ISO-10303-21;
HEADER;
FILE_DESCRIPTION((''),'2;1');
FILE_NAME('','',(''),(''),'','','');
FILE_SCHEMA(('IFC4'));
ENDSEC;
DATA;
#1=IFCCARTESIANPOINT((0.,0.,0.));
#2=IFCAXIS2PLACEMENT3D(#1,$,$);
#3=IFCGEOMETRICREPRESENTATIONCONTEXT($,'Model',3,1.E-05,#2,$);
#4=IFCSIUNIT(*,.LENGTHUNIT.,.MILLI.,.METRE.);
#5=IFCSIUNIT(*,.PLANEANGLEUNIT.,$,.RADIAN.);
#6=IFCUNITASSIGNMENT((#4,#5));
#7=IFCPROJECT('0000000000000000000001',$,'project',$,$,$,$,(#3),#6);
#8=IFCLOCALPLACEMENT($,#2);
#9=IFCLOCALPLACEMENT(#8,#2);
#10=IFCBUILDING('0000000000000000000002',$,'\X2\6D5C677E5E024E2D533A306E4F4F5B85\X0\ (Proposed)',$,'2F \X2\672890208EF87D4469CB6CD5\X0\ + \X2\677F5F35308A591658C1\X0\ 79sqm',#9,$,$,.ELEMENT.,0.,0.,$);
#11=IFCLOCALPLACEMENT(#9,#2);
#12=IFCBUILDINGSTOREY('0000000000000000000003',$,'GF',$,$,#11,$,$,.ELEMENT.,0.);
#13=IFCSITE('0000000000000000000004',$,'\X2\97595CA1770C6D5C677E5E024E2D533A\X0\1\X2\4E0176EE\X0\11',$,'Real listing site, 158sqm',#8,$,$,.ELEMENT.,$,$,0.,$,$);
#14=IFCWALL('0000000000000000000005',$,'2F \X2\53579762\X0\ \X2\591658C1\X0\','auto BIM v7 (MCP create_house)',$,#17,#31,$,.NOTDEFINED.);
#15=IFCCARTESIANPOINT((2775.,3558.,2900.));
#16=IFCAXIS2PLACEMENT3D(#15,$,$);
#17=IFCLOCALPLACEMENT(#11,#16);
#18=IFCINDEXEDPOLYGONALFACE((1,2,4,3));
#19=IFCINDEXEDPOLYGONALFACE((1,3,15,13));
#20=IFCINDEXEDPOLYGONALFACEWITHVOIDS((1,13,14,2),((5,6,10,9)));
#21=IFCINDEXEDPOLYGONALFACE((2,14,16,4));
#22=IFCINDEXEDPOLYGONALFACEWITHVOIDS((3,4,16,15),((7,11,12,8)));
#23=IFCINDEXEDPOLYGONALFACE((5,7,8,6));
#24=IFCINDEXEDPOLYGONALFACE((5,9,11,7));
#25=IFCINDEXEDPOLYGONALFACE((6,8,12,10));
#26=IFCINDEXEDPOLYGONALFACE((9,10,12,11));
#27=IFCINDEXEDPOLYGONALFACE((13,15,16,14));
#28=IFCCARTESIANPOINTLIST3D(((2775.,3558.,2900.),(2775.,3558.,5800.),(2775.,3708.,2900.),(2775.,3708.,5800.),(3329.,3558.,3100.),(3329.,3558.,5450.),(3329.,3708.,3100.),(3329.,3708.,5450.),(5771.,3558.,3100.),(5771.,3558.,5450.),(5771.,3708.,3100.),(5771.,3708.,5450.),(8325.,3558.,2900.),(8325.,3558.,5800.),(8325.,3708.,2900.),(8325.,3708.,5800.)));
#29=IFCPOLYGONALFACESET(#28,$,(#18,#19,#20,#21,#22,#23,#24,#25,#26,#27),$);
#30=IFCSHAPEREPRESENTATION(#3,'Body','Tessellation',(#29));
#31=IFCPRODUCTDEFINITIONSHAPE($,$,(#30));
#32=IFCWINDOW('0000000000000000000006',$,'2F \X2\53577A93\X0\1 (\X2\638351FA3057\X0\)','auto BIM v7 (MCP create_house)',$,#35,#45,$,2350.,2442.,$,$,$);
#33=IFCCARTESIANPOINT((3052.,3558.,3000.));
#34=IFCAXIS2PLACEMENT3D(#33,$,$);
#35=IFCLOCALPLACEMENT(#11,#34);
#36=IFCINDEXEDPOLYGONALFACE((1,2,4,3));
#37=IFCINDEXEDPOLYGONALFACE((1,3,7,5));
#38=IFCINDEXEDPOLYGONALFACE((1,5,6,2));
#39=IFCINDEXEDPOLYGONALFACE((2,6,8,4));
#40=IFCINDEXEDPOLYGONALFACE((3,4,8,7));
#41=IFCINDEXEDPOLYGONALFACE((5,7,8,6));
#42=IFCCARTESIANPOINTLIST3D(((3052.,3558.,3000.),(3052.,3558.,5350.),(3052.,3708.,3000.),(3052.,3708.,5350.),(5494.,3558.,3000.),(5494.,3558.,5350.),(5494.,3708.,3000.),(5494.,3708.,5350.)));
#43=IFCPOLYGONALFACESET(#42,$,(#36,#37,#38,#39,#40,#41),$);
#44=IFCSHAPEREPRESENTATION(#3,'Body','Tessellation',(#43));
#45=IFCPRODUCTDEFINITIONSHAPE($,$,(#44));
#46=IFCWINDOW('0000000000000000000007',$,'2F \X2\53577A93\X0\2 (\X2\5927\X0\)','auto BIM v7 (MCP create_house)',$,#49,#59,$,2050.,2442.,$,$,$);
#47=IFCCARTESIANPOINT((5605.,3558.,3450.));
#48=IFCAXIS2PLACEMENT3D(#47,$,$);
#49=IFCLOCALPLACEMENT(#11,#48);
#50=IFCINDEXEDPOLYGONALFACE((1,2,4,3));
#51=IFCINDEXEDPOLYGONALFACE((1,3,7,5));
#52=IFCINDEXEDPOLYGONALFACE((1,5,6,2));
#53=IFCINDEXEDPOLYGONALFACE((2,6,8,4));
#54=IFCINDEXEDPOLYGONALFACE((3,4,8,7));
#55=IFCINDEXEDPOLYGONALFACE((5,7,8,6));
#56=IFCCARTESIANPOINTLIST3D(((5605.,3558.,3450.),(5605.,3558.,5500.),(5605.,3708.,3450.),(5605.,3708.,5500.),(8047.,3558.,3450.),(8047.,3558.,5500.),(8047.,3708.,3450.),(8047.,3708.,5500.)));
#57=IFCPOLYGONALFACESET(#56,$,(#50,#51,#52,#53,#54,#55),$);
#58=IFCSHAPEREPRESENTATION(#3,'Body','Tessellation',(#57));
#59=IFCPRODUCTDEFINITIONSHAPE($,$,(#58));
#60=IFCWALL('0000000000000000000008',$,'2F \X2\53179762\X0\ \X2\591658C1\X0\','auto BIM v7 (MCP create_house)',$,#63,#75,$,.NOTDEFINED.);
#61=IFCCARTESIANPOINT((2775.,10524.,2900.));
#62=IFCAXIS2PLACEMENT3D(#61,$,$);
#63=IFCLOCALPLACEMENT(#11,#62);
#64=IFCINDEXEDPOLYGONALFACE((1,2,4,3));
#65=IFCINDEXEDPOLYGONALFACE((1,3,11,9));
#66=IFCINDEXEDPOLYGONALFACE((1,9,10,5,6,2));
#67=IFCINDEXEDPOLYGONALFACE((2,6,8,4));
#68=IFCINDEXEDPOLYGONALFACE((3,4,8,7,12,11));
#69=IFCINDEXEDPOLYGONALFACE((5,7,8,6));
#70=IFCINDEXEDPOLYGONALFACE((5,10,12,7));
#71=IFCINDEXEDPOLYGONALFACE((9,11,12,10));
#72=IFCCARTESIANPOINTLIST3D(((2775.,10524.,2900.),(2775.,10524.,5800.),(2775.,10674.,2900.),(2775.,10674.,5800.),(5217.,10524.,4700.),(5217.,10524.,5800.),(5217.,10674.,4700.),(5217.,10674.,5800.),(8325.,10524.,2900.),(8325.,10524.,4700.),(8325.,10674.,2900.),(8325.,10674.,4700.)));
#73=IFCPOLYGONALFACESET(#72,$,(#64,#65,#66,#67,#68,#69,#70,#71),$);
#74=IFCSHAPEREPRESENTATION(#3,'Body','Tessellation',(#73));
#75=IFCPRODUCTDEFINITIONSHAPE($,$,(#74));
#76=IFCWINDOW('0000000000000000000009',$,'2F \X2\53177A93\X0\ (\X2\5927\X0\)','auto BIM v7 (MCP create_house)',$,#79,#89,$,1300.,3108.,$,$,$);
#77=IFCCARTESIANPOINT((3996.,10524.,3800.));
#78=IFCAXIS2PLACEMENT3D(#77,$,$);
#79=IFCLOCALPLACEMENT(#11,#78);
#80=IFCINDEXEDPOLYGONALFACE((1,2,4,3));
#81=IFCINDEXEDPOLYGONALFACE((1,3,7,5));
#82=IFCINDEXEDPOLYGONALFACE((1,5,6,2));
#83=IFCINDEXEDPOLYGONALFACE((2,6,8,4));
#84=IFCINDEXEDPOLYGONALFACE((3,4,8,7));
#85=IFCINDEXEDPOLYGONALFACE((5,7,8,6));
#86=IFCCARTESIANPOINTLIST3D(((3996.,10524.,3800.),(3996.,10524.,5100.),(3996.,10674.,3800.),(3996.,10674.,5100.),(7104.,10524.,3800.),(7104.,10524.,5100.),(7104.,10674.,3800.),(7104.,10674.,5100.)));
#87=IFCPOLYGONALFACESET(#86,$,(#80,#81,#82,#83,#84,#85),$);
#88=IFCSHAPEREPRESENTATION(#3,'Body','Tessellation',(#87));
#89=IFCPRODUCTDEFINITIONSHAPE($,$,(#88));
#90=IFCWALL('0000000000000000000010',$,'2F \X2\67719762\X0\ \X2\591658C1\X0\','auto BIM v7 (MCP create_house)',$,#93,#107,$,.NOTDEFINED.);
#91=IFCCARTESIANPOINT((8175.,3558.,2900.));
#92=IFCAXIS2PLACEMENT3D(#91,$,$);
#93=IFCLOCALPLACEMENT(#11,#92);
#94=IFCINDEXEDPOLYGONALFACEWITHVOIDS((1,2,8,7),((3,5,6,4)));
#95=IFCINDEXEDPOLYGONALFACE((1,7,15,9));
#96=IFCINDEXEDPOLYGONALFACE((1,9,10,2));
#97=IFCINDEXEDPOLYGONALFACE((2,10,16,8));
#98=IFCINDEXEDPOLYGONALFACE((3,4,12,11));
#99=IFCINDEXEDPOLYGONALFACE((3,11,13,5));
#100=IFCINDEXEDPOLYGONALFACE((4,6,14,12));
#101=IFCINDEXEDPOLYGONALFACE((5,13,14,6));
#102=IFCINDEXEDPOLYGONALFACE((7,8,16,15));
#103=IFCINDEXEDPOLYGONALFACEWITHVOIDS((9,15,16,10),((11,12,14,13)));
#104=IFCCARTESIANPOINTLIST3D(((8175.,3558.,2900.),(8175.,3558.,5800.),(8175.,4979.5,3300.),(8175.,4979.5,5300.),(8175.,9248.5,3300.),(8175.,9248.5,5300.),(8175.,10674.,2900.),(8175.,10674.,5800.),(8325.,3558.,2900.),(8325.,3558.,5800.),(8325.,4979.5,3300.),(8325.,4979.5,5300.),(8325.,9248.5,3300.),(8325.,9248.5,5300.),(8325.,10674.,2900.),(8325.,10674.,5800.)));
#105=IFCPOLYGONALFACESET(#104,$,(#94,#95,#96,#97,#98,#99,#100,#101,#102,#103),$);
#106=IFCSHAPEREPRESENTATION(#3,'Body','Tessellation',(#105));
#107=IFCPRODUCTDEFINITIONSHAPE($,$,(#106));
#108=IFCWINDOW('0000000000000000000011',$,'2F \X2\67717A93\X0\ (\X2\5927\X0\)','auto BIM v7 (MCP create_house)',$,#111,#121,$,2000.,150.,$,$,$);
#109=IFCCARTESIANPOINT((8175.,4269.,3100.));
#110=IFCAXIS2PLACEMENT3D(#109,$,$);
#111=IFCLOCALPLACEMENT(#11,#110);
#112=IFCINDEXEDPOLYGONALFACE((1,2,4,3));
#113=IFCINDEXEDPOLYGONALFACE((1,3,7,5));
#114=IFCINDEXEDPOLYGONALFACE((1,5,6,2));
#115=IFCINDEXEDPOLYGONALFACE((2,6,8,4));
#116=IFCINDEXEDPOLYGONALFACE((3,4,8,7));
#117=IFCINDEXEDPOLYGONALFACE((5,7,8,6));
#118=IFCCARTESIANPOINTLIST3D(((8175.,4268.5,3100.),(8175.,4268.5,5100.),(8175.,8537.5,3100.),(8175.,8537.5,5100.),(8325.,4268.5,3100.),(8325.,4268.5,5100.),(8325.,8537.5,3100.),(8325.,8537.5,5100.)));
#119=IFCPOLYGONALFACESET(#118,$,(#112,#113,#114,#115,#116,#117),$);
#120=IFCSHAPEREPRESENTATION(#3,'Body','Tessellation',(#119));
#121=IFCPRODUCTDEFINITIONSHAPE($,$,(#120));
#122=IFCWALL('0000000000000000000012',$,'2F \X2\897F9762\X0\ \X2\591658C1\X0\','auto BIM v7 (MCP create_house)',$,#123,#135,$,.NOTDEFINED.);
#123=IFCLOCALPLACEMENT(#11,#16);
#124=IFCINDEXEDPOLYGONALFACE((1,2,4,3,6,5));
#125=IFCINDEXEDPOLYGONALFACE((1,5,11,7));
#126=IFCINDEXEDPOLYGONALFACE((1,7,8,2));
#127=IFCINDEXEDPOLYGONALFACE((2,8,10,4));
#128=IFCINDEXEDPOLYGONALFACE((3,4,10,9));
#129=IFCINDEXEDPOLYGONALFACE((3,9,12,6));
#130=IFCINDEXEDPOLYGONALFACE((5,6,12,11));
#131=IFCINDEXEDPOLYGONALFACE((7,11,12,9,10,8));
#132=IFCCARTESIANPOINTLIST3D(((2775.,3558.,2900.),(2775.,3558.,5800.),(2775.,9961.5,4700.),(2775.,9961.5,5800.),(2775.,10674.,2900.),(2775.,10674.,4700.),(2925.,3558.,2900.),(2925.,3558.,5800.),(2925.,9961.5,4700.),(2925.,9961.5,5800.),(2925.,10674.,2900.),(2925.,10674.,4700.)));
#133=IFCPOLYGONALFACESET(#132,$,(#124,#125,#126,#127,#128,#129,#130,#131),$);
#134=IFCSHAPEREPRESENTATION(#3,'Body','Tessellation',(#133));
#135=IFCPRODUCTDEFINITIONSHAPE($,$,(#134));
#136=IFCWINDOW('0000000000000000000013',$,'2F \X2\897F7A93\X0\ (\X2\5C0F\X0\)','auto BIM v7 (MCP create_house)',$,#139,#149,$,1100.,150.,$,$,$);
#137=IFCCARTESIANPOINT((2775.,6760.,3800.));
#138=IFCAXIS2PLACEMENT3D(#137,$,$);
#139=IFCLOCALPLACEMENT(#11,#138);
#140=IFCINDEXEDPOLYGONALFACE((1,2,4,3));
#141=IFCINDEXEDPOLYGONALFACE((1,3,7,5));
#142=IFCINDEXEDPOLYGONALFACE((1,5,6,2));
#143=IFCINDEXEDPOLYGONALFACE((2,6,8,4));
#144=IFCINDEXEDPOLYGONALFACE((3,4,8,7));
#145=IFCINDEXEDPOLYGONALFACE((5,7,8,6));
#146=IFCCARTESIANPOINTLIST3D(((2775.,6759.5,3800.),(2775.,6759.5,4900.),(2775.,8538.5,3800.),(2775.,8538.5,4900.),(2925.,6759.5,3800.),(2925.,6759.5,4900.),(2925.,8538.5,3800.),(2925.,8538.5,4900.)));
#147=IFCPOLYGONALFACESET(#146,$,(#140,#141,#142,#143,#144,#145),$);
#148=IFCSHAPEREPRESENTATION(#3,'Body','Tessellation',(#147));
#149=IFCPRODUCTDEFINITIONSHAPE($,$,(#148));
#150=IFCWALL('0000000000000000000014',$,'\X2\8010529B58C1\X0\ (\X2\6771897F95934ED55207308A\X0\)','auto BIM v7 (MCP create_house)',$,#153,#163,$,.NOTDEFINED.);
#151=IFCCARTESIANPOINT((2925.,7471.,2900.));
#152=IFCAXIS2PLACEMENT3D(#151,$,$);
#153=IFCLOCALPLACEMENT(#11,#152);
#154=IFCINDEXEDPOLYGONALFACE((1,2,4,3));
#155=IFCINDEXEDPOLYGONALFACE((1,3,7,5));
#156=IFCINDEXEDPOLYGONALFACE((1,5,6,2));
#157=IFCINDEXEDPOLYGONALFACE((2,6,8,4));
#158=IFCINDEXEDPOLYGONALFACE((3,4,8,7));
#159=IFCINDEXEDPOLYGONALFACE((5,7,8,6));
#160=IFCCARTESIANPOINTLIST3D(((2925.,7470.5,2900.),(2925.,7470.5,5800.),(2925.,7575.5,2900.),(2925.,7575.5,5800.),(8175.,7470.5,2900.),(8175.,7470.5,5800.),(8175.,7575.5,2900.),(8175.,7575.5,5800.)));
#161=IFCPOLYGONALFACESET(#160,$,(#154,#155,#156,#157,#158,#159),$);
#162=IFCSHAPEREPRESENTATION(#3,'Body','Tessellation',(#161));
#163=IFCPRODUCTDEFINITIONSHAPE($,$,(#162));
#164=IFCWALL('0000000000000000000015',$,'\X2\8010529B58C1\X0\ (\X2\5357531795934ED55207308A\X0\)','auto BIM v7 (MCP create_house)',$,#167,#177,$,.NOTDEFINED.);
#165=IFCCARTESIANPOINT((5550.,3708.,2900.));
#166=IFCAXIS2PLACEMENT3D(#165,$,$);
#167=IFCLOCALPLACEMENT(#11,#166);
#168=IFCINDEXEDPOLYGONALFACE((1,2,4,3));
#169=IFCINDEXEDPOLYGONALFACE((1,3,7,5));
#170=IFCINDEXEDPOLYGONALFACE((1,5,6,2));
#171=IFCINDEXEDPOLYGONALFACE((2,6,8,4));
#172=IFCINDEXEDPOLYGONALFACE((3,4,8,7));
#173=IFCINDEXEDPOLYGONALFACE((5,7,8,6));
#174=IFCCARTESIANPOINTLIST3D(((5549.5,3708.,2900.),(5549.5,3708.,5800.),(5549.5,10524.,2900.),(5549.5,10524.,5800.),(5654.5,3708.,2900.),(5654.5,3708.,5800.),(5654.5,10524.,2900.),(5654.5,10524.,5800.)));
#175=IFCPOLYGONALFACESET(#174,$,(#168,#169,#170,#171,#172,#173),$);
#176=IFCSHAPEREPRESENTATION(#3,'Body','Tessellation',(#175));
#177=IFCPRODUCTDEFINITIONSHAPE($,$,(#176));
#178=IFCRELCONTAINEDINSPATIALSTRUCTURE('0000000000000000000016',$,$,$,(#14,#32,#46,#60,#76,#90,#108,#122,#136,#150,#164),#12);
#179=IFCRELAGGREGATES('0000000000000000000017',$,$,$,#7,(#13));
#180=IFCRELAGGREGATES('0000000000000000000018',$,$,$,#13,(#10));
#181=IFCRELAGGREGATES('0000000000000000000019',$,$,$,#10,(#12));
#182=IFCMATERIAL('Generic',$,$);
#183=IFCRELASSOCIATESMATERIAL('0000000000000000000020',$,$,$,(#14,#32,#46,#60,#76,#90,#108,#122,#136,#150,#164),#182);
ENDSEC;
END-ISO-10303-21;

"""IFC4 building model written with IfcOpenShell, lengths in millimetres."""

from ifc_helpers import new_model, si_unit, frame, frame_2d, origin, place, context, project, spatial, rectangle, extrude, material, element, fill, save


model = new_model("IFC4")

# Units and contexts
model_context = context("Model", 3, precision=1e-05, world=origin())
ifc_project = project(units=[si_unit("LENGTHUNIT", "METRE", prefix="MILLI"), si_unit("PLANEANGLEUNIT", "RADIAN")], contexts=[model_context])

# Site, building, storey
site_placement = place(None, origin())
site = spatial("IfcSite", under=ifc_project, at=site_placement, Name="静岡県浜松市中区1丁目11", ObjectType="Real listing site, 158sqm", CompositionType="ELEMENT", RefElevation=0.0)
building_placement = place(site_placement, origin())
building = spatial("IfcBuilding", under=site, at=building_placement, Name="浜松市中区の住宅 (Proposed)", ObjectType="2F 木造軸組構法 + 板張り外壁 79sqm", CompositionType="ELEMENT", ElevationOfRefHeight=0.0, ElevationOfTerrain=0.0)
storey_placement = place(building_placement, origin())
storey = spatial("IfcBuildingStorey", under=building, at=storey_placement, Name="GF", CompositionType="ELEMENT", Elevation=0.0)

# Shared definitions
ifc_material = material(Name="Generic")

# Wall, openings, windows
wall_1_placement = place(storey_placement, frame((2775.0, 3558.0, 2900.0)))
wall_1 = element("IfcWall", 1, at=wall_1_placement, inside=storey, material=ifc_material, Name="2F 南面 外壁", Description="auto BIM v7 (MCP create_house)", PredefinedType="NOTDEFINED", context=model_context, shape_type="SweptSolid", body=[
    extrude(rectangle(XDim=5550.0, YDim=150.0, at=frame_2d((2775.0, 75.0))), frame((2775.0, 3558.0, 2900.0)), (0.0, 0.0, 1.0), 2900.0),
])
opening_1_placement = place(storey_placement, frame((3052.0, 3558.0, 3000.0)))
opening_1 = element("IfcOpeningElement", 2, at=opening_1_placement, cuts=wall_1, PredefinedType="NOTDEFINED", context=model_context, shape_type="SweptSolid", body=[
    extrude(rectangle(XDim=2442.0, YDim=150.0, at=frame_2d((1221.0, 75.0))), frame((3052.0, 3558.0, 3000.0)), (0.0, 0.0, 1.0), 2350.0),
])
opening_2_placement = place(storey_placement, frame((5605.0, 3558.0, 3450.0)))
opening_2 = element("IfcOpeningElement", 3, at=opening_2_placement, cuts=wall_1, PredefinedType="NOTDEFINED", context=model_context, shape_type="SweptSolid", body=[
    extrude(rectangle(XDim=2442.0, YDim=150.0, at=frame_2d((1221.0, 75.0))), frame((5605.0, 3558.0, 3450.0)), (0.0, 0.0, 1.0), 2050.0),
])
window_1_placement = place(storey_placement, frame((3052.0, 3558.0, 3000.0)))
window_1 = element("IfcWindow", 4, at=window_1_placement, inside=storey, material=ifc_material, Name="2F 南窓1 (掃出し)", Description="auto BIM v7 (MCP create_house)", OverallHeight=2350.0, OverallWidth=2442.0, context=model_context, shape_type="SweptSolid", body=[
    extrude(rectangle(XDim=2442.0, YDim=150.0, at=frame_2d((1221.0, 75.0))), frame((3052.0, 3558.0, 3000.0)), (0.0, 0.0, 1.0), 2350.0),
])
fill(opening_1, window_1)
window_2_placement = place(storey_placement, frame((5605.0, 3558.0, 3450.0)))
window_2 = element("IfcWindow", 5, at=window_2_placement, inside=storey, material=ifc_material, Name="2F 南窓2 (大)", Description="auto BIM v7 (MCP create_house)", OverallHeight=2050.0, OverallWidth=2442.0, context=model_context, shape_type="SweptSolid", body=[
    extrude(rectangle(XDim=2442.0, YDim=150.0, at=frame_2d((1221.0, 75.0))), frame((5605.0, 3558.0, 3450.0)), (0.0, 0.0, 1.0), 2050.0),
])
fill(opening_2, window_2)

# Walls, openings, windows
wall_2_placement = place(storey_placement, frame((2775.0, 10524.0, 2900.0)))
wall_2 = element("IfcWall", 6, at=wall_2_placement, inside=storey, material=ifc_material, Name="2F 北面 外壁", Description="auto BIM v7 (MCP create_house)", PredefinedType="NOTDEFINED", context=model_context, shape_type="SweptSolid", body=[
    extrude(rectangle(XDim=5550.0, YDim=150.0, at=frame_2d((2775.0, 75.0))), frame((2775.0, 10524.0, 2900.0)), (0.0, 0.0, 1.0), 2900.0),
])
opening_3_placement = place(storey_placement, frame((3996.0, 10524.0, 3800.0)))
opening_3 = element("IfcOpeningElement", 7, at=opening_3_placement, cuts=wall_2, PredefinedType="NOTDEFINED", context=model_context, shape_type="SweptSolid", body=[
    extrude(rectangle(XDim=3108.0, YDim=150.0, at=frame_2d((1554.0, 75.0))), frame((3996.0, 10524.0, 3800.0)), (0.0, 0.0, 1.0), 1300.0),
])
window_3_placement = place(storey_placement, frame((3996.0, 10524.0, 3800.0)))
window_3 = element("IfcWindow", 8, at=window_3_placement, inside=storey, material=ifc_material, Name="2F 北窓 (大)", Description="auto BIM v7 (MCP create_house)", OverallHeight=1300.0, OverallWidth=3108.0, context=model_context, shape_type="SweptSolid", body=[
    extrude(rectangle(XDim=3108.0, YDim=150.0, at=frame_2d((1554.0, 75.0))), frame((3996.0, 10524.0, 3800.0)), (0.0, 0.0, 1.0), 1300.0),
])
fill(opening_3, window_3)
wall_3_placement = place(storey_placement, frame((8175.0, 3558.0, 2900.0)))
wall_3 = element("IfcWall", 9, at=wall_3_placement, inside=storey, material=ifc_material, Name="2F 東面 外壁", Description="auto BIM v7 (MCP create_house)", PredefinedType="NOTDEFINED", context=model_context, shape_type="SweptSolid", body=[
    extrude(rectangle(XDim=150.0, YDim=7116.0, at=frame_2d((75.0, 3558.0))), frame((8175.0, 3558.0, 2900.0)), (0.0, 0.0, 1.0), 2900.0),
])
opening_4_placement = place(storey_placement, frame((8175.0, 4269.0, 3100.0)))
opening_4 = element("IfcOpeningElement", 10, at=opening_4_placement, cuts=wall_3, PredefinedType="NOTDEFINED", context=model_context, shape_type="SweptSolid", body=[
    extrude(rectangle(XDim=150.0, YDim=4269.0, at=frame_2d((75.0, 2134.0))), frame((8175.0, 4269.0, 3100.0)), (0.0, 0.0, 1.0), 2000.0),
])
window_4_placement = place(storey_placement, frame((8175.0, 4269.0, 3100.0)))
window_4 = element("IfcWindow", 11, at=window_4_placement, inside=storey, material=ifc_material, Name="2F 東窓 (大)", Description="auto BIM v7 (MCP create_house)", OverallHeight=2000.0, OverallWidth=150.0, context=model_context, shape_type="SweptSolid", body=[
    extrude(rectangle(XDim=150.0, YDim=4269.0, at=frame_2d((75.0, 2134.0))), frame((8175.0, 4269.0, 3100.0)), (0.0, 0.0, 1.0), 2000.0),
])
fill(opening_4, window_4)
wall_4_placement = place(storey_placement, frame((2775.0, 3558.0, 2900.0)))
wall_4 = element("IfcWall", 12, at=wall_4_placement, inside=storey, material=ifc_material, Name="2F 西面 外壁", Description="auto BIM v7 (MCP create_house)", PredefinedType="NOTDEFINED", context=model_context, shape_type="SweptSolid", body=[
    extrude(rectangle(XDim=150.0, YDim=7116.0, at=frame_2d((75.0, 3558.0))), frame((2775.0, 3558.0, 2900.0)), (0.0, 0.0, 1.0), 2900.0),
])
opening_5_placement = place(storey_placement, frame((2775.0, 6760.0, 3800.0)))
opening_5 = element("IfcOpeningElement", 13, at=opening_5_placement, cuts=wall_4, PredefinedType="NOTDEFINED", context=model_context, shape_type="SweptSolid", body=[
    extrude(rectangle(XDim=150.0, YDim=1779.0, at=frame_2d((75.0, 889.0))), frame((2775.0, 6760.0, 3800.0)), (0.0, 0.0, 1.0), 1100.0),
])
window_5_placement = place(storey_placement, frame((2775.0, 6760.0, 3800.0)))
window_5 = element("IfcWindow", 14, at=window_5_placement, inside=storey, material=ifc_material, Name="2F 西窓 (小)", Description="auto BIM v7 (MCP create_house)", OverallHeight=1100.0, OverallWidth=150.0, context=model_context, shape_type="SweptSolid", body=[
    extrude(rectangle(XDim=150.0, YDim=1779.0, at=frame_2d((75.0, 889.0))), frame((2775.0, 6760.0, 3800.0)), (0.0, 0.0, 1.0), 1100.0),
])
fill(opening_5, window_5)

# Walls
wall_5_placement = place(storey_placement, frame((2925.0, 7471.0, 2900.0)))
element("IfcWall", 15, at=wall_5_placement, inside=storey, material=ifc_material, Name="耐力壁 (東西間仕切り)", Description="auto BIM v7 (MCP create_house)", PredefinedType="NOTDEFINED", context=model_context, shape_type="SweptSolid", body=[
    extrude(rectangle(XDim=5250.0, YDim=105.0, at=frame_2d((2625.0, 52.0))), frame((2925.0, 7471.0, 2900.0)), (0.0, 0.0, 1.0), 2900.0),
])
wall_6_placement = place(storey_placement, frame((5550.0, 3708.0, 2900.0)))
element("IfcWall", 16, at=wall_6_placement, inside=storey, material=ifc_material, Name="耐力壁 (南北間仕切り)", Description="auto BIM v7 (MCP create_house)", PredefinedType="NOTDEFINED", context=model_context, shape_type="SweptSolid", body=[
    extrude(rectangle(XDim=105.0, YDim=6816.0, at=frame_2d((52.0, 3408.0))), frame((5550.0, 3708.0, 2900.0)), (0.0, 0.0, 1.0), 2900.0),
])

save(model, "model.ifc")
